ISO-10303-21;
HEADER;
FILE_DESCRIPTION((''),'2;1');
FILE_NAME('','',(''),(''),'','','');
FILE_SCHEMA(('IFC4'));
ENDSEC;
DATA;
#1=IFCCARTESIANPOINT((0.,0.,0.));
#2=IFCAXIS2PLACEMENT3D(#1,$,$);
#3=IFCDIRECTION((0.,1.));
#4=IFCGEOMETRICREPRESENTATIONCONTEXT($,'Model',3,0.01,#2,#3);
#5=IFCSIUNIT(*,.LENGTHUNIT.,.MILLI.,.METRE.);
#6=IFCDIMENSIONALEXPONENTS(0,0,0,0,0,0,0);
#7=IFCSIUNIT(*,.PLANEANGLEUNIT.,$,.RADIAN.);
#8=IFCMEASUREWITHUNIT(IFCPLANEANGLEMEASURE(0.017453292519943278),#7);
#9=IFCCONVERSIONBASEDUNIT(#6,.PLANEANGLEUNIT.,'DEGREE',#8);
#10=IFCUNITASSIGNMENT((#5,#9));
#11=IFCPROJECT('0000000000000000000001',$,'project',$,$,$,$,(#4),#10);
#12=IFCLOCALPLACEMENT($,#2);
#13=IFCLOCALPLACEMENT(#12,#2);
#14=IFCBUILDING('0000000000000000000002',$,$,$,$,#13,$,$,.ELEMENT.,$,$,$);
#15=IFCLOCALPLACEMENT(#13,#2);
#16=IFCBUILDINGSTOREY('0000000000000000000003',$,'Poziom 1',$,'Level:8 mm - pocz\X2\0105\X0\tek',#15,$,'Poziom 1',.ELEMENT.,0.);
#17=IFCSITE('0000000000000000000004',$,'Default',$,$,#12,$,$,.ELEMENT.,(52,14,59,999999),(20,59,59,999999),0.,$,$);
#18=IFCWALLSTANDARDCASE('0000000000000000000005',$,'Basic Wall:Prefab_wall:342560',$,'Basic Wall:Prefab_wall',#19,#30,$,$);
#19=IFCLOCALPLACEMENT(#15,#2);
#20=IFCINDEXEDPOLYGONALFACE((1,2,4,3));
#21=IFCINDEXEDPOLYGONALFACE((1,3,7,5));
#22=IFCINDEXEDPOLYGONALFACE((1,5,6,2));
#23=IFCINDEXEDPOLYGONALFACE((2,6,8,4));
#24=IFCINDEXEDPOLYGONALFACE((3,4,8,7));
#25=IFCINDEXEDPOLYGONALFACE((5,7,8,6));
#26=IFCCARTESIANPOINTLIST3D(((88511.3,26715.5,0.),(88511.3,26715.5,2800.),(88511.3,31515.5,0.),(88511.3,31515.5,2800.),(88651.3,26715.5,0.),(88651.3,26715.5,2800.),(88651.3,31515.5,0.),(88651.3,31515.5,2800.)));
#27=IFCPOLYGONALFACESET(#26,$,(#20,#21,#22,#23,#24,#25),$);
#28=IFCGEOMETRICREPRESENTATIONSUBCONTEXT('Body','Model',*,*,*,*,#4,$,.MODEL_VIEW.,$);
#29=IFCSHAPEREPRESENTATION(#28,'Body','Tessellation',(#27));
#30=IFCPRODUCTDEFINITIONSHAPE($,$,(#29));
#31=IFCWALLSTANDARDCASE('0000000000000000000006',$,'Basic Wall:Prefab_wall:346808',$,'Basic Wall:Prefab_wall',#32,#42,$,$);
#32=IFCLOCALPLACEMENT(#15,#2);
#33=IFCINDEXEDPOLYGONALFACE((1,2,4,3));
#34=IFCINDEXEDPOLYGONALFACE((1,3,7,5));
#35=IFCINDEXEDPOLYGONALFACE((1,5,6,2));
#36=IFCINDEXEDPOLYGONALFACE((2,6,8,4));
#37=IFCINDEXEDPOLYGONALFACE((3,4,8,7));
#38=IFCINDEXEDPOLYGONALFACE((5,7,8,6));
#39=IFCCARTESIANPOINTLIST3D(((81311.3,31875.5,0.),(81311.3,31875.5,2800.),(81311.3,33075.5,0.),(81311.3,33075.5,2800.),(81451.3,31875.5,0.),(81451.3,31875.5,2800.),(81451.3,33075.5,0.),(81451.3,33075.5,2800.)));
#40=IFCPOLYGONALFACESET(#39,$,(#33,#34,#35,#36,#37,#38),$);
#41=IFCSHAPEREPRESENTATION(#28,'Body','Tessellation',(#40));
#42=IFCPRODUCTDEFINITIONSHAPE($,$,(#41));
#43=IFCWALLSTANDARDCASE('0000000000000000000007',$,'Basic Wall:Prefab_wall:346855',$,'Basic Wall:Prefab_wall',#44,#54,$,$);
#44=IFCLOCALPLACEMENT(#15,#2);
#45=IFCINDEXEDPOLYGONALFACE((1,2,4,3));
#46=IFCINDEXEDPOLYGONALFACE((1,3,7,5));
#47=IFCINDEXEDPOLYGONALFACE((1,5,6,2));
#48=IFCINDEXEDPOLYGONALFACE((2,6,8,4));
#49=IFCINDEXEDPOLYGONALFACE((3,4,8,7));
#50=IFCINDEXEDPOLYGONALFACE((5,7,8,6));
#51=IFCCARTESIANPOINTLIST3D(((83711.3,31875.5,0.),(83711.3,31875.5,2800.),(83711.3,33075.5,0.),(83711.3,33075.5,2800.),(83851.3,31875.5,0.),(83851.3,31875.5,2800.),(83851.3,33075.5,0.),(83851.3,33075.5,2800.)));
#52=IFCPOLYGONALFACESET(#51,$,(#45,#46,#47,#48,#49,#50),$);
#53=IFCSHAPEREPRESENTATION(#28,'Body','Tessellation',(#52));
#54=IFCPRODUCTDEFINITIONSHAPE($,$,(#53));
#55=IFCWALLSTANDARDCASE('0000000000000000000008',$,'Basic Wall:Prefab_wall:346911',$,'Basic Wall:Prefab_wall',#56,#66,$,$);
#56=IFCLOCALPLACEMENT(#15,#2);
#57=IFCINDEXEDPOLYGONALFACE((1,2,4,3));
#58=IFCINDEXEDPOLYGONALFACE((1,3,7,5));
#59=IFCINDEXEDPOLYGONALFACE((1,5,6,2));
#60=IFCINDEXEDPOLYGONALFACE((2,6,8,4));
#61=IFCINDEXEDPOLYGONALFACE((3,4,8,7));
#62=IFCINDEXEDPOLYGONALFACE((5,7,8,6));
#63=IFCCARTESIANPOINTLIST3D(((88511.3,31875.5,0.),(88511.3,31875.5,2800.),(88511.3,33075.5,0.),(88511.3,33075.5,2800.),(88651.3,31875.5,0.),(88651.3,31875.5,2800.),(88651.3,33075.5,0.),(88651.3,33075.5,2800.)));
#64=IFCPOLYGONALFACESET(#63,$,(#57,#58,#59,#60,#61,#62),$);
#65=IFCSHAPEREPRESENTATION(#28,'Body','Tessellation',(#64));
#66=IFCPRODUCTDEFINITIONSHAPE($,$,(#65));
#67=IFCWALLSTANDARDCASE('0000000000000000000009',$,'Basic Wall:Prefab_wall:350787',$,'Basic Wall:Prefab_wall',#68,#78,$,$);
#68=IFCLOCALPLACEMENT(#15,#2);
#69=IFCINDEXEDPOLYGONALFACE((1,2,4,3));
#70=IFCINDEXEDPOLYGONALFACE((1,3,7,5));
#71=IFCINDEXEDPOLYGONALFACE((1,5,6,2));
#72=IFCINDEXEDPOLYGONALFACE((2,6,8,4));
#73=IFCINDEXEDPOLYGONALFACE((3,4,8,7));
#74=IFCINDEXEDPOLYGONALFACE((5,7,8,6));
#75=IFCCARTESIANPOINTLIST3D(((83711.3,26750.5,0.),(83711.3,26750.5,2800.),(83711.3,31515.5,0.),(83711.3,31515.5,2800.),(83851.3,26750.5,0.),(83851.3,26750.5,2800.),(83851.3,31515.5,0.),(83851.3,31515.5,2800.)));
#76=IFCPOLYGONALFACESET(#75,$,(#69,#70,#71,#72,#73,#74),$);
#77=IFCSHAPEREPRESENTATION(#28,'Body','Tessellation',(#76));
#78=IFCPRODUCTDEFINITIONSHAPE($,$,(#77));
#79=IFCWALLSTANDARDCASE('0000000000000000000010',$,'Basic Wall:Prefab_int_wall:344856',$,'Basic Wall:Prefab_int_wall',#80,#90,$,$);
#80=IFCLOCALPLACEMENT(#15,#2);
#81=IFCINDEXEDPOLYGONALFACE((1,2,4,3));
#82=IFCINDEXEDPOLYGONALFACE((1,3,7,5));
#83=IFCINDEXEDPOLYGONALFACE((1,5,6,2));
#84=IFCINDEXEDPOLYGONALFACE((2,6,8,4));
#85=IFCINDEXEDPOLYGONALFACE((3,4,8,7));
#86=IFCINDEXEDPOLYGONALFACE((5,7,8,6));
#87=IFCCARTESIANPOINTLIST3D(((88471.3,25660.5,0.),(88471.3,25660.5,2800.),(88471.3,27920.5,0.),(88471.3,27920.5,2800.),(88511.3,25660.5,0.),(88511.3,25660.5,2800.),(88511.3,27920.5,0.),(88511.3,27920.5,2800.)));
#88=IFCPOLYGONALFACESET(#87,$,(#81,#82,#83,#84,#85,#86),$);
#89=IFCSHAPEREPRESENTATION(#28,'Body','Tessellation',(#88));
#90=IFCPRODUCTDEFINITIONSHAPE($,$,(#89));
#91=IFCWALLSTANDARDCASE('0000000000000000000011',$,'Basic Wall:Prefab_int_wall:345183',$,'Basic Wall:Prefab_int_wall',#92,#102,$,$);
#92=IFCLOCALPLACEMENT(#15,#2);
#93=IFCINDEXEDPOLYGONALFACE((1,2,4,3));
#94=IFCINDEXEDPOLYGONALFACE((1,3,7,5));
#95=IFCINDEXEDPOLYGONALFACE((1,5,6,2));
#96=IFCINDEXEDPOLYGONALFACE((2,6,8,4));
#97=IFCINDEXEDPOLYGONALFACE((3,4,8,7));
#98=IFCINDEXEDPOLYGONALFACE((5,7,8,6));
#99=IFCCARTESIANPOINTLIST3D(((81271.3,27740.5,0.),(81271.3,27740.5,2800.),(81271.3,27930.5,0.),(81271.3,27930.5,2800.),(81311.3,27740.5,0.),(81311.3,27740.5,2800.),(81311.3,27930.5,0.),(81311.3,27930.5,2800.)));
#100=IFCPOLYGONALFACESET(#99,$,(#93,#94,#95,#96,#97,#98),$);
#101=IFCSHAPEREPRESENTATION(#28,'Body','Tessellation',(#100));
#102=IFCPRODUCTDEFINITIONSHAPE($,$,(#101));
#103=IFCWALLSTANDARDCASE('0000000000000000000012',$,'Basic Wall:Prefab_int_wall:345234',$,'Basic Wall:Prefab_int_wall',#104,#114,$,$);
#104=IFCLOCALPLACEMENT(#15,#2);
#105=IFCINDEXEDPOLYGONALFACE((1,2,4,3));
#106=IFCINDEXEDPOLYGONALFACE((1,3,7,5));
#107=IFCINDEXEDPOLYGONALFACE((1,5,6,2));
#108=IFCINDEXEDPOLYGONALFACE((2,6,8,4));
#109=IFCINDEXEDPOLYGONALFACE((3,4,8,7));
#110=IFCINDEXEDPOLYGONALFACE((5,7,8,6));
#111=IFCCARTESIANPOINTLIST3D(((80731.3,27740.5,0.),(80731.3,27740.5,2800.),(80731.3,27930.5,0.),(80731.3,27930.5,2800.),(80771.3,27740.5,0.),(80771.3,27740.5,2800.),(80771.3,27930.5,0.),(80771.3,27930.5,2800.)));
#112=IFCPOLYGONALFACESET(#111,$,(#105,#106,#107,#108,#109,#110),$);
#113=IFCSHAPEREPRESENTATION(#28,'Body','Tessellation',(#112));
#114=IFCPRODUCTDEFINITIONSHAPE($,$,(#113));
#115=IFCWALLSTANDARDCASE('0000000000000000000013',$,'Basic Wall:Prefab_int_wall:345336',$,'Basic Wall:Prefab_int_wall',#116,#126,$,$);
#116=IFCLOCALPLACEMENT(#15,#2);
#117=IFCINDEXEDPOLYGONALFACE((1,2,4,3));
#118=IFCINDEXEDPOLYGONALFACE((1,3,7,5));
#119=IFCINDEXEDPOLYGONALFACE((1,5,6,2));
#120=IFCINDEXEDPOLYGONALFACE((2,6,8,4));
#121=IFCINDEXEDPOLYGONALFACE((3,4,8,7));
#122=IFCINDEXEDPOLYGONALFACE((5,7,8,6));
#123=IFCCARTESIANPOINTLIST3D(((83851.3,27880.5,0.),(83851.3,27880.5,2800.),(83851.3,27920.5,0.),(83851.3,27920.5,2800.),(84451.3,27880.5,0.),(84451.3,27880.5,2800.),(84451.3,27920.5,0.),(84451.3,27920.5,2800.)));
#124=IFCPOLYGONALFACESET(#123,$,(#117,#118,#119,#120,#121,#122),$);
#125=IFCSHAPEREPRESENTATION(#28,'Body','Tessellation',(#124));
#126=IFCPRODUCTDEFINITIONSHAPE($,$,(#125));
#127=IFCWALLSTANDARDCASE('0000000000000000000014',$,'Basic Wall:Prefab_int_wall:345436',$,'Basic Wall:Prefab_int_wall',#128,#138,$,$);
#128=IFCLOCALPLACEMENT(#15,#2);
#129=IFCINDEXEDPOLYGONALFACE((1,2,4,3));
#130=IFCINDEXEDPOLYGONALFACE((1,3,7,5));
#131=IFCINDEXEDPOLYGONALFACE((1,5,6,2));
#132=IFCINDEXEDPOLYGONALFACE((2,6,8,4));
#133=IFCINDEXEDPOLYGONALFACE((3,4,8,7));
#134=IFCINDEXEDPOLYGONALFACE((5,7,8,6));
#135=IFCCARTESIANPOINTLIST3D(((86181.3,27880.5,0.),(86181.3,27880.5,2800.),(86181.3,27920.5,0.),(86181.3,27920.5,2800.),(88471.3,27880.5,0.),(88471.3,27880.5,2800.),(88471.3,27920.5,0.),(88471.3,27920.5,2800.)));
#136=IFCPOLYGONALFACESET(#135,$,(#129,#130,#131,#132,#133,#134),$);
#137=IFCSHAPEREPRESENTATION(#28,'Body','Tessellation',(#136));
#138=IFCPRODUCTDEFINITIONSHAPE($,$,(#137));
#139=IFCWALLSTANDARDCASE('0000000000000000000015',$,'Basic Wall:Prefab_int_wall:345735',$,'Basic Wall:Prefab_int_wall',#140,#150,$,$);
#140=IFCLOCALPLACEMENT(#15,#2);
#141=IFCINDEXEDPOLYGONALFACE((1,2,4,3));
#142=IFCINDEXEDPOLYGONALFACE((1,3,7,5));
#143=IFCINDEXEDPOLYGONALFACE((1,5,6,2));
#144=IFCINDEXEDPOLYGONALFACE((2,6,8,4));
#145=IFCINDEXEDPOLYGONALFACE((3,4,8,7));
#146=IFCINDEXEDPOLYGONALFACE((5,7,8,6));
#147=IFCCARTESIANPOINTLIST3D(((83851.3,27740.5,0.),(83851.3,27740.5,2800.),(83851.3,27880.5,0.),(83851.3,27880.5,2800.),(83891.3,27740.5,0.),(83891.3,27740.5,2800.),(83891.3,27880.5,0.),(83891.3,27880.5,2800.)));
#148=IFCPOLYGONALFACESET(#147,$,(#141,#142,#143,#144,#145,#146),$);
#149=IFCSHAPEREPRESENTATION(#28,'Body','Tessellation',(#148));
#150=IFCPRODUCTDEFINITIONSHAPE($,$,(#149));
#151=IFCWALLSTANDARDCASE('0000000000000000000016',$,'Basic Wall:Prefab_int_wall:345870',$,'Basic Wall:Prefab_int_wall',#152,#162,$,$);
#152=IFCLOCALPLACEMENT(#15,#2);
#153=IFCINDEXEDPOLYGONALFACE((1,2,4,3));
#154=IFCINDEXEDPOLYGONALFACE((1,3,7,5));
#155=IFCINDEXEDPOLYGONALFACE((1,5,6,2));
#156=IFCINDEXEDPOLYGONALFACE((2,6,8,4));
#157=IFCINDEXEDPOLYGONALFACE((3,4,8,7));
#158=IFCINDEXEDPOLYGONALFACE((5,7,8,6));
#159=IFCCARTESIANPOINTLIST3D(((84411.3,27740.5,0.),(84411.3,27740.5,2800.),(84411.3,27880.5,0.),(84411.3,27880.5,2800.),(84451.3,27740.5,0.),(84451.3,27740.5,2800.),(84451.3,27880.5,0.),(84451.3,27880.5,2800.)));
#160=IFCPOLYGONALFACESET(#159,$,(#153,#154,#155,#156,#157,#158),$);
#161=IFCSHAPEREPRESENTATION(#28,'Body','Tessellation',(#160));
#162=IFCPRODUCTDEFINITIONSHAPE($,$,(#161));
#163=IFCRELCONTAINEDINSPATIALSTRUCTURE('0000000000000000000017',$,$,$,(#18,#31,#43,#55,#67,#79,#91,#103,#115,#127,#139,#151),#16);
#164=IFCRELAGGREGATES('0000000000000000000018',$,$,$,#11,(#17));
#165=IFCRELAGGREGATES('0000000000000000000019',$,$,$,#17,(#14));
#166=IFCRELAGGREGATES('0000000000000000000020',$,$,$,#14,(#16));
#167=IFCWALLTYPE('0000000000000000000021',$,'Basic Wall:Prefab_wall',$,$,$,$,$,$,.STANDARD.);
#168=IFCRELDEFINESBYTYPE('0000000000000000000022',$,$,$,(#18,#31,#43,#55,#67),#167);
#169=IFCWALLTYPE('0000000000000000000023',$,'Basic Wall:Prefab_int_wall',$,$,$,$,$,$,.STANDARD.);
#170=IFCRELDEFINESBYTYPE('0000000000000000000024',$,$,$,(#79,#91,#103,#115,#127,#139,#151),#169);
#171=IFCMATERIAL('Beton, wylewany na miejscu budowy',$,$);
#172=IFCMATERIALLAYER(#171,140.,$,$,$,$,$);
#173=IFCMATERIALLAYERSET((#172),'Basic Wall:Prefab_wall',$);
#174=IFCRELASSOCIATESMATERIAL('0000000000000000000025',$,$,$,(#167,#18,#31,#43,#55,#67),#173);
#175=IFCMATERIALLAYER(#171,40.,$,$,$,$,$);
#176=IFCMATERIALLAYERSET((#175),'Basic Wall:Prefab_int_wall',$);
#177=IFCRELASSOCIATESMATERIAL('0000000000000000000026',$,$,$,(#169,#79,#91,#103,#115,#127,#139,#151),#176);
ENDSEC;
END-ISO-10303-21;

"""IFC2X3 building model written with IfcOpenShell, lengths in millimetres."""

from ifc_helpers import new_model, entity, si_unit, converted_unit, direction, frame, frame_2d, origin, place, context, subcontext, project, spatial, rectangle, extrude, material, layer, layer_set, layer_usage, type_object, element, save


model = new_model("IFC2X3")

# Units and contexts
model_context = context("Model", 3, precision=0.01, world=origin(), true_north=direction((0.0, 1.0)))
body_context = subcontext(model_context, "Body", "Model", "MODEL_VIEW")
ifc_project = project(units=[si_unit("LENGTHUNIT", "METRE", prefix="MILLI"), converted_unit("PLANEANGLEUNIT", "DEGREE", entity("IfcPlaneAngleMeasure", 0.017453292519943278), si_unit("PLANEANGLEUNIT", "RADIAN"), dimensions=[0, 0, 0, 0, 0, 0, 0])], contexts=[model_context])

# Site, building, storey
site_placement = place(None, origin())
site = spatial("IfcSite", under=ifc_project, at=site_placement, Name="Default", CompositionType="ELEMENT", RefLatitude=(52, 14, 59, 999999), RefLongitude=(20, 59, 59, 999999), RefElevation=0.0)
building_placement = place(site_placement, origin())
building = spatial("IfcBuilding", under=site, at=building_placement, CompositionType="ELEMENT")
storey_placement = place(building_placement, origin())
storey = spatial("IfcBuildingStorey", under=building, at=storey_placement, Name="Poziom 1", ObjectType="Level:8 mm - początek", LongName="Poziom 1", CompositionType="ELEMENT", Elevation=0.0)

# Walls
ifc_material = material(Name="Beton, wylewany na miejscu budowy")
ifc_layer_1 = layer(ifc_material, 140.0)
ifc_layer_set_1 = layer_set([ifc_layer_1], Name="Basic Wall:Prefab_wall")
ifc_layer_usage_1 = layer_usage(ifc_layer_set_1, "AXIS2", "NEGATIVE", 70.0)
wall_type_1 = type_object("IfcWallType", Name="Basic Wall:Prefab_wall", PredefinedType="STANDARD", material=ifc_layer_set_1)
wall_1_placement = place(storey_placement, frame((88581.3, 31515.5, 0.0), z_axis=(0.0, 0.0, 1.0), x_axis=(0.0, -1.0, 0.0)))
element("IfcWallStandardCase", 1, at=wall_1_placement, inside=storey, type_object=wall_type_1, material=ifc_layer_usage_1, Name="Basic Wall:Prefab_wall:342560", ObjectType="Basic Wall:Prefab_wall", context=body_context, shape_type="SweptSolid", body=[
    extrude(rectangle(XDim=4800.0, YDim=140.0, at=frame_2d((2400.0, 0.0), x_axis=(-1.0, 0.0))), origin(), (0.0, 0.0, 1.0), 2800.0),
])
ifc_layer_usage_2 = layer_usage(ifc_layer_set_1, "AXIS2", "NEGATIVE", 70.0)
wall_2_placement = place(storey_placement, frame((81381.3, 33075.5, 0.0), z_axis=(0.0, 0.0, 1.0), x_axis=(0.0, -1.0, 0.0)))
element("IfcWallStandardCase", 2, at=wall_2_placement, inside=storey, type_object=wall_type_1, material=ifc_layer_usage_2, Name="Basic Wall:Prefab_wall:346808", ObjectType="Basic Wall:Prefab_wall", context=body_context, shape_type="SweptSolid", body=[
    extrude(rectangle(XDim=1200.0, YDim=140.0, at=frame_2d((600.0, 0.0), x_axis=(-1.0, 0.0))), origin(), (0.0, 0.0, 1.0), 2800.0),
])
ifc_layer_usage_3 = layer_usage(ifc_layer_set_1, "AXIS2", "NEGATIVE", 70.0)
wall_3_placement = place(storey_placement, frame((83781.3, 33075.5, 0.0), z_axis=(0.0, 0.0, 1.0), x_axis=(0.0, -1.0, 0.0)))
element("IfcWallStandardCase", 3, at=wall_3_placement, inside=storey, type_object=wall_type_1, material=ifc_layer_usage_3, Name="Basic Wall:Prefab_wall:346855", ObjectType="Basic Wall:Prefab_wall", context=body_context, shape_type="SweptSolid", body=[
    extrude(rectangle(XDim=1200.0, YDim=140.0, at=frame_2d((600.0, 0.0), x_axis=(-1.0, 0.0))), origin(), (0.0, 0.0, 1.0), 2800.0),
])
ifc_layer_usage_4 = layer_usage(ifc_layer_set_1, "AXIS2", "NEGATIVE", 70.0)
wall_4_placement = place(storey_placement, frame((88581.3, 33075.5, 0.0), z_axis=(0.0, 0.0, 1.0), x_axis=(0.0, -1.0, 0.0)))
element("IfcWallStandardCase", 4, at=wall_4_placement, inside=storey, type_object=wall_type_1, material=ifc_layer_usage_4, Name="Basic Wall:Prefab_wall:346911", ObjectType="Basic Wall:Prefab_wall", context=body_context, shape_type="SweptSolid", body=[
    extrude(rectangle(XDim=1200.0, YDim=140.0, at=frame_2d((600.0, 0.0), x_axis=(-1.0, 0.0))), origin(), (0.0, 0.0, 1.0), 2800.0),
])
ifc_layer_usage_5 = layer_usage(ifc_layer_set_1, "AXIS2", "NEGATIVE", 70.0)
wall_5_placement = place(storey_placement, frame((83781.3, 26750.5, 0.0), z_axis=(0.0, 0.0, 1.0), x_axis=(0.0, 1.0, 0.0)))
element("IfcWallStandardCase", 5, at=wall_5_placement, inside=storey, type_object=wall_type_1, material=ifc_layer_usage_5, Name="Basic Wall:Prefab_wall:350787", ObjectType="Basic Wall:Prefab_wall", context=body_context, shape_type="SweptSolid", body=[
    extrude(rectangle(XDim=4765.0, YDim=140.0, at=frame_2d((2382.5, 0.0), x_axis=(-1.0, 0.0))), origin(), (0.0, 0.0, 1.0), 2800.0),
])
ifc_layer_2 = layer(ifc_material, 40.0)
ifc_layer_set_2 = layer_set([ifc_layer_2], Name="Basic Wall:Prefab_int_wall")
ifc_layer_usage_6 = layer_usage(ifc_layer_set_2, "AXIS2", "NEGATIVE", 20.0)
wall_type_2 = type_object("IfcWallType", Name="Basic Wall:Prefab_int_wall", PredefinedType="STANDARD", material=ifc_layer_set_2)
wall_6_placement = place(storey_placement, frame((88491.3, 27920.5, 0.0), z_axis=(0.0, 0.0, 1.0), x_axis=(0.0, -1.0, 0.0)))
element("IfcWallStandardCase", 6, at=wall_6_placement, inside=storey, type_object=wall_type_2, material=ifc_layer_usage_6, Name="Basic Wall:Prefab_int_wall:344856", ObjectType="Basic Wall:Prefab_int_wall", context=body_context, shape_type="SweptSolid", body=[
    extrude(rectangle(XDim=2260.0, YDim=40.0, at=frame_2d((1130.0, 0.0), x_axis=(-1.0, 0.0))), origin(), (0.0, 0.0, 1.0), 2800.0),
])
ifc_layer_usage_7 = layer_usage(ifc_layer_set_2, "AXIS2", "NEGATIVE", 20.0)
wall_7_placement = place(storey_placement, frame((81291.3, 27930.5, 0.0), z_axis=(0.0, 0.0, 1.0), x_axis=(0.0, -1.0, 0.0)))
element("IfcWallStandardCase", 7, at=wall_7_placement, inside=storey, type_object=wall_type_2, material=ifc_layer_usage_7, Name="Basic Wall:Prefab_int_wall:345183", ObjectType="Basic Wall:Prefab_int_wall", context=body_context, shape_type="SweptSolid", body=[
    extrude(rectangle(XDim=190.0, YDim=40.0, at=frame_2d((95.0, 0.0), x_axis=(-1.0, 0.0))), origin(), (0.0, 0.0, 1.0), 2800.0),
])
ifc_layer_usage_8 = layer_usage(ifc_layer_set_2, "AXIS2", "NEGATIVE", 20.0)
wall_8_placement = place(storey_placement, frame((80751.3, 27930.5, 0.0), z_axis=(0.0, 0.0, 1.0), x_axis=(0.0, -1.0, 0.0)))
element("IfcWallStandardCase", 8, at=wall_8_placement, inside=storey, type_object=wall_type_2, material=ifc_layer_usage_8, Name="Basic Wall:Prefab_int_wall:345234", ObjectType="Basic Wall:Prefab_int_wall", context=body_context, shape_type="SweptSolid", body=[
    extrude(rectangle(XDim=190.0, YDim=40.0, at=frame_2d((95.0, 0.0), x_axis=(-1.0, 0.0))), origin(), (0.0, 0.0, 1.0), 2800.0),
])
ifc_layer_usage_9 = layer_usage(ifc_layer_set_2, "AXIS2", "NEGATIVE", 20.0)
wall_9_placement = place(storey_placement, frame((84451.3, 27900.5, 0.0), z_axis=(0.0, 0.0, 1.0), x_axis=(-1.0, 0.0, 0.0)))
element("IfcWallStandardCase", 9, at=wall_9_placement, inside=storey, type_object=wall_type_2, material=ifc_layer_usage_9, Name="Basic Wall:Prefab_int_wall:345336", ObjectType="Basic Wall:Prefab_int_wall", context=body_context, shape_type="SweptSolid", body=[
    extrude(rectangle(XDim=600.0, YDim=40.0, at=frame_2d((300.0, 0.0), x_axis=(-1.0, 0.0))), origin(), (0.0, 0.0, 1.0), 2800.0),
])
ifc_layer_usage_10 = layer_usage(ifc_layer_set_2, "AXIS2", "NEGATIVE", 20.0)
wall_10_placement = place(storey_placement, frame((86181.3, 27900.5, 0.0)))
element("IfcWallStandardCase", 10, at=wall_10_placement, inside=storey, type_object=wall_type_2, material=ifc_layer_usage_10, Name="Basic Wall:Prefab_int_wall:345436", ObjectType="Basic Wall:Prefab_int_wall", context=body_context, shape_type="SweptSolid", body=[
    extrude(rectangle(XDim=2290.0, YDim=40.0, at=frame_2d((1145.0, 0.0), x_axis=(-1.0, 0.0))), origin(), (0.0, 0.0, 1.0), 2800.0),
])
ifc_layer_usage_11 = layer_usage(ifc_layer_set_2, "AXIS2", "NEGATIVE", 20.0)
wall_11_placement = place(storey_placement, frame((83871.3, 27880.5, 0.0), z_axis=(0.0, 0.0, 1.0), x_axis=(0.0, -1.0, 0.0)))
element("IfcWallStandardCase", 11, at=wall_11_placement, inside=storey, type_object=wall_type_2, material=ifc_layer_usage_11, Name="Basic Wall:Prefab_int_wall:345735", ObjectType="Basic Wall:Prefab_int_wall", context=body_context, shape_type="SweptSolid", body=[
    extrude(rectangle(XDim=140.0, YDim=40.0, at=frame_2d((70.0, 0.0), x_axis=(-1.0, 0.0))), origin(), (0.0, 0.0, 1.0), 2800.0),
])
ifc_layer_usage_12 = layer_usage(ifc_layer_set_2, "AXIS2", "NEGATIVE", 20.0)
wall_12_placement = place(storey_placement, frame((84431.3, 27880.5, 0.0), z_axis=(0.0, 0.0, 1.0), x_axis=(0.0, -1.0, 0.0)))
element("IfcWallStandardCase", 12, at=wall_12_placement, inside=storey, type_object=wall_type_2, material=ifc_layer_usage_12, Name="Basic Wall:Prefab_int_wall:345870", ObjectType="Basic Wall:Prefab_int_wall", context=body_context, shape_type="SweptSolid", body=[
    extrude(rectangle(XDim=140.0, YDim=40.0, at=frame_2d((70.0, 0.0), x_axis=(-1.0, 0.0))), origin(), (0.0, 0.0, 1.0), 2800.0),
])

save(model, "model.ifc")
